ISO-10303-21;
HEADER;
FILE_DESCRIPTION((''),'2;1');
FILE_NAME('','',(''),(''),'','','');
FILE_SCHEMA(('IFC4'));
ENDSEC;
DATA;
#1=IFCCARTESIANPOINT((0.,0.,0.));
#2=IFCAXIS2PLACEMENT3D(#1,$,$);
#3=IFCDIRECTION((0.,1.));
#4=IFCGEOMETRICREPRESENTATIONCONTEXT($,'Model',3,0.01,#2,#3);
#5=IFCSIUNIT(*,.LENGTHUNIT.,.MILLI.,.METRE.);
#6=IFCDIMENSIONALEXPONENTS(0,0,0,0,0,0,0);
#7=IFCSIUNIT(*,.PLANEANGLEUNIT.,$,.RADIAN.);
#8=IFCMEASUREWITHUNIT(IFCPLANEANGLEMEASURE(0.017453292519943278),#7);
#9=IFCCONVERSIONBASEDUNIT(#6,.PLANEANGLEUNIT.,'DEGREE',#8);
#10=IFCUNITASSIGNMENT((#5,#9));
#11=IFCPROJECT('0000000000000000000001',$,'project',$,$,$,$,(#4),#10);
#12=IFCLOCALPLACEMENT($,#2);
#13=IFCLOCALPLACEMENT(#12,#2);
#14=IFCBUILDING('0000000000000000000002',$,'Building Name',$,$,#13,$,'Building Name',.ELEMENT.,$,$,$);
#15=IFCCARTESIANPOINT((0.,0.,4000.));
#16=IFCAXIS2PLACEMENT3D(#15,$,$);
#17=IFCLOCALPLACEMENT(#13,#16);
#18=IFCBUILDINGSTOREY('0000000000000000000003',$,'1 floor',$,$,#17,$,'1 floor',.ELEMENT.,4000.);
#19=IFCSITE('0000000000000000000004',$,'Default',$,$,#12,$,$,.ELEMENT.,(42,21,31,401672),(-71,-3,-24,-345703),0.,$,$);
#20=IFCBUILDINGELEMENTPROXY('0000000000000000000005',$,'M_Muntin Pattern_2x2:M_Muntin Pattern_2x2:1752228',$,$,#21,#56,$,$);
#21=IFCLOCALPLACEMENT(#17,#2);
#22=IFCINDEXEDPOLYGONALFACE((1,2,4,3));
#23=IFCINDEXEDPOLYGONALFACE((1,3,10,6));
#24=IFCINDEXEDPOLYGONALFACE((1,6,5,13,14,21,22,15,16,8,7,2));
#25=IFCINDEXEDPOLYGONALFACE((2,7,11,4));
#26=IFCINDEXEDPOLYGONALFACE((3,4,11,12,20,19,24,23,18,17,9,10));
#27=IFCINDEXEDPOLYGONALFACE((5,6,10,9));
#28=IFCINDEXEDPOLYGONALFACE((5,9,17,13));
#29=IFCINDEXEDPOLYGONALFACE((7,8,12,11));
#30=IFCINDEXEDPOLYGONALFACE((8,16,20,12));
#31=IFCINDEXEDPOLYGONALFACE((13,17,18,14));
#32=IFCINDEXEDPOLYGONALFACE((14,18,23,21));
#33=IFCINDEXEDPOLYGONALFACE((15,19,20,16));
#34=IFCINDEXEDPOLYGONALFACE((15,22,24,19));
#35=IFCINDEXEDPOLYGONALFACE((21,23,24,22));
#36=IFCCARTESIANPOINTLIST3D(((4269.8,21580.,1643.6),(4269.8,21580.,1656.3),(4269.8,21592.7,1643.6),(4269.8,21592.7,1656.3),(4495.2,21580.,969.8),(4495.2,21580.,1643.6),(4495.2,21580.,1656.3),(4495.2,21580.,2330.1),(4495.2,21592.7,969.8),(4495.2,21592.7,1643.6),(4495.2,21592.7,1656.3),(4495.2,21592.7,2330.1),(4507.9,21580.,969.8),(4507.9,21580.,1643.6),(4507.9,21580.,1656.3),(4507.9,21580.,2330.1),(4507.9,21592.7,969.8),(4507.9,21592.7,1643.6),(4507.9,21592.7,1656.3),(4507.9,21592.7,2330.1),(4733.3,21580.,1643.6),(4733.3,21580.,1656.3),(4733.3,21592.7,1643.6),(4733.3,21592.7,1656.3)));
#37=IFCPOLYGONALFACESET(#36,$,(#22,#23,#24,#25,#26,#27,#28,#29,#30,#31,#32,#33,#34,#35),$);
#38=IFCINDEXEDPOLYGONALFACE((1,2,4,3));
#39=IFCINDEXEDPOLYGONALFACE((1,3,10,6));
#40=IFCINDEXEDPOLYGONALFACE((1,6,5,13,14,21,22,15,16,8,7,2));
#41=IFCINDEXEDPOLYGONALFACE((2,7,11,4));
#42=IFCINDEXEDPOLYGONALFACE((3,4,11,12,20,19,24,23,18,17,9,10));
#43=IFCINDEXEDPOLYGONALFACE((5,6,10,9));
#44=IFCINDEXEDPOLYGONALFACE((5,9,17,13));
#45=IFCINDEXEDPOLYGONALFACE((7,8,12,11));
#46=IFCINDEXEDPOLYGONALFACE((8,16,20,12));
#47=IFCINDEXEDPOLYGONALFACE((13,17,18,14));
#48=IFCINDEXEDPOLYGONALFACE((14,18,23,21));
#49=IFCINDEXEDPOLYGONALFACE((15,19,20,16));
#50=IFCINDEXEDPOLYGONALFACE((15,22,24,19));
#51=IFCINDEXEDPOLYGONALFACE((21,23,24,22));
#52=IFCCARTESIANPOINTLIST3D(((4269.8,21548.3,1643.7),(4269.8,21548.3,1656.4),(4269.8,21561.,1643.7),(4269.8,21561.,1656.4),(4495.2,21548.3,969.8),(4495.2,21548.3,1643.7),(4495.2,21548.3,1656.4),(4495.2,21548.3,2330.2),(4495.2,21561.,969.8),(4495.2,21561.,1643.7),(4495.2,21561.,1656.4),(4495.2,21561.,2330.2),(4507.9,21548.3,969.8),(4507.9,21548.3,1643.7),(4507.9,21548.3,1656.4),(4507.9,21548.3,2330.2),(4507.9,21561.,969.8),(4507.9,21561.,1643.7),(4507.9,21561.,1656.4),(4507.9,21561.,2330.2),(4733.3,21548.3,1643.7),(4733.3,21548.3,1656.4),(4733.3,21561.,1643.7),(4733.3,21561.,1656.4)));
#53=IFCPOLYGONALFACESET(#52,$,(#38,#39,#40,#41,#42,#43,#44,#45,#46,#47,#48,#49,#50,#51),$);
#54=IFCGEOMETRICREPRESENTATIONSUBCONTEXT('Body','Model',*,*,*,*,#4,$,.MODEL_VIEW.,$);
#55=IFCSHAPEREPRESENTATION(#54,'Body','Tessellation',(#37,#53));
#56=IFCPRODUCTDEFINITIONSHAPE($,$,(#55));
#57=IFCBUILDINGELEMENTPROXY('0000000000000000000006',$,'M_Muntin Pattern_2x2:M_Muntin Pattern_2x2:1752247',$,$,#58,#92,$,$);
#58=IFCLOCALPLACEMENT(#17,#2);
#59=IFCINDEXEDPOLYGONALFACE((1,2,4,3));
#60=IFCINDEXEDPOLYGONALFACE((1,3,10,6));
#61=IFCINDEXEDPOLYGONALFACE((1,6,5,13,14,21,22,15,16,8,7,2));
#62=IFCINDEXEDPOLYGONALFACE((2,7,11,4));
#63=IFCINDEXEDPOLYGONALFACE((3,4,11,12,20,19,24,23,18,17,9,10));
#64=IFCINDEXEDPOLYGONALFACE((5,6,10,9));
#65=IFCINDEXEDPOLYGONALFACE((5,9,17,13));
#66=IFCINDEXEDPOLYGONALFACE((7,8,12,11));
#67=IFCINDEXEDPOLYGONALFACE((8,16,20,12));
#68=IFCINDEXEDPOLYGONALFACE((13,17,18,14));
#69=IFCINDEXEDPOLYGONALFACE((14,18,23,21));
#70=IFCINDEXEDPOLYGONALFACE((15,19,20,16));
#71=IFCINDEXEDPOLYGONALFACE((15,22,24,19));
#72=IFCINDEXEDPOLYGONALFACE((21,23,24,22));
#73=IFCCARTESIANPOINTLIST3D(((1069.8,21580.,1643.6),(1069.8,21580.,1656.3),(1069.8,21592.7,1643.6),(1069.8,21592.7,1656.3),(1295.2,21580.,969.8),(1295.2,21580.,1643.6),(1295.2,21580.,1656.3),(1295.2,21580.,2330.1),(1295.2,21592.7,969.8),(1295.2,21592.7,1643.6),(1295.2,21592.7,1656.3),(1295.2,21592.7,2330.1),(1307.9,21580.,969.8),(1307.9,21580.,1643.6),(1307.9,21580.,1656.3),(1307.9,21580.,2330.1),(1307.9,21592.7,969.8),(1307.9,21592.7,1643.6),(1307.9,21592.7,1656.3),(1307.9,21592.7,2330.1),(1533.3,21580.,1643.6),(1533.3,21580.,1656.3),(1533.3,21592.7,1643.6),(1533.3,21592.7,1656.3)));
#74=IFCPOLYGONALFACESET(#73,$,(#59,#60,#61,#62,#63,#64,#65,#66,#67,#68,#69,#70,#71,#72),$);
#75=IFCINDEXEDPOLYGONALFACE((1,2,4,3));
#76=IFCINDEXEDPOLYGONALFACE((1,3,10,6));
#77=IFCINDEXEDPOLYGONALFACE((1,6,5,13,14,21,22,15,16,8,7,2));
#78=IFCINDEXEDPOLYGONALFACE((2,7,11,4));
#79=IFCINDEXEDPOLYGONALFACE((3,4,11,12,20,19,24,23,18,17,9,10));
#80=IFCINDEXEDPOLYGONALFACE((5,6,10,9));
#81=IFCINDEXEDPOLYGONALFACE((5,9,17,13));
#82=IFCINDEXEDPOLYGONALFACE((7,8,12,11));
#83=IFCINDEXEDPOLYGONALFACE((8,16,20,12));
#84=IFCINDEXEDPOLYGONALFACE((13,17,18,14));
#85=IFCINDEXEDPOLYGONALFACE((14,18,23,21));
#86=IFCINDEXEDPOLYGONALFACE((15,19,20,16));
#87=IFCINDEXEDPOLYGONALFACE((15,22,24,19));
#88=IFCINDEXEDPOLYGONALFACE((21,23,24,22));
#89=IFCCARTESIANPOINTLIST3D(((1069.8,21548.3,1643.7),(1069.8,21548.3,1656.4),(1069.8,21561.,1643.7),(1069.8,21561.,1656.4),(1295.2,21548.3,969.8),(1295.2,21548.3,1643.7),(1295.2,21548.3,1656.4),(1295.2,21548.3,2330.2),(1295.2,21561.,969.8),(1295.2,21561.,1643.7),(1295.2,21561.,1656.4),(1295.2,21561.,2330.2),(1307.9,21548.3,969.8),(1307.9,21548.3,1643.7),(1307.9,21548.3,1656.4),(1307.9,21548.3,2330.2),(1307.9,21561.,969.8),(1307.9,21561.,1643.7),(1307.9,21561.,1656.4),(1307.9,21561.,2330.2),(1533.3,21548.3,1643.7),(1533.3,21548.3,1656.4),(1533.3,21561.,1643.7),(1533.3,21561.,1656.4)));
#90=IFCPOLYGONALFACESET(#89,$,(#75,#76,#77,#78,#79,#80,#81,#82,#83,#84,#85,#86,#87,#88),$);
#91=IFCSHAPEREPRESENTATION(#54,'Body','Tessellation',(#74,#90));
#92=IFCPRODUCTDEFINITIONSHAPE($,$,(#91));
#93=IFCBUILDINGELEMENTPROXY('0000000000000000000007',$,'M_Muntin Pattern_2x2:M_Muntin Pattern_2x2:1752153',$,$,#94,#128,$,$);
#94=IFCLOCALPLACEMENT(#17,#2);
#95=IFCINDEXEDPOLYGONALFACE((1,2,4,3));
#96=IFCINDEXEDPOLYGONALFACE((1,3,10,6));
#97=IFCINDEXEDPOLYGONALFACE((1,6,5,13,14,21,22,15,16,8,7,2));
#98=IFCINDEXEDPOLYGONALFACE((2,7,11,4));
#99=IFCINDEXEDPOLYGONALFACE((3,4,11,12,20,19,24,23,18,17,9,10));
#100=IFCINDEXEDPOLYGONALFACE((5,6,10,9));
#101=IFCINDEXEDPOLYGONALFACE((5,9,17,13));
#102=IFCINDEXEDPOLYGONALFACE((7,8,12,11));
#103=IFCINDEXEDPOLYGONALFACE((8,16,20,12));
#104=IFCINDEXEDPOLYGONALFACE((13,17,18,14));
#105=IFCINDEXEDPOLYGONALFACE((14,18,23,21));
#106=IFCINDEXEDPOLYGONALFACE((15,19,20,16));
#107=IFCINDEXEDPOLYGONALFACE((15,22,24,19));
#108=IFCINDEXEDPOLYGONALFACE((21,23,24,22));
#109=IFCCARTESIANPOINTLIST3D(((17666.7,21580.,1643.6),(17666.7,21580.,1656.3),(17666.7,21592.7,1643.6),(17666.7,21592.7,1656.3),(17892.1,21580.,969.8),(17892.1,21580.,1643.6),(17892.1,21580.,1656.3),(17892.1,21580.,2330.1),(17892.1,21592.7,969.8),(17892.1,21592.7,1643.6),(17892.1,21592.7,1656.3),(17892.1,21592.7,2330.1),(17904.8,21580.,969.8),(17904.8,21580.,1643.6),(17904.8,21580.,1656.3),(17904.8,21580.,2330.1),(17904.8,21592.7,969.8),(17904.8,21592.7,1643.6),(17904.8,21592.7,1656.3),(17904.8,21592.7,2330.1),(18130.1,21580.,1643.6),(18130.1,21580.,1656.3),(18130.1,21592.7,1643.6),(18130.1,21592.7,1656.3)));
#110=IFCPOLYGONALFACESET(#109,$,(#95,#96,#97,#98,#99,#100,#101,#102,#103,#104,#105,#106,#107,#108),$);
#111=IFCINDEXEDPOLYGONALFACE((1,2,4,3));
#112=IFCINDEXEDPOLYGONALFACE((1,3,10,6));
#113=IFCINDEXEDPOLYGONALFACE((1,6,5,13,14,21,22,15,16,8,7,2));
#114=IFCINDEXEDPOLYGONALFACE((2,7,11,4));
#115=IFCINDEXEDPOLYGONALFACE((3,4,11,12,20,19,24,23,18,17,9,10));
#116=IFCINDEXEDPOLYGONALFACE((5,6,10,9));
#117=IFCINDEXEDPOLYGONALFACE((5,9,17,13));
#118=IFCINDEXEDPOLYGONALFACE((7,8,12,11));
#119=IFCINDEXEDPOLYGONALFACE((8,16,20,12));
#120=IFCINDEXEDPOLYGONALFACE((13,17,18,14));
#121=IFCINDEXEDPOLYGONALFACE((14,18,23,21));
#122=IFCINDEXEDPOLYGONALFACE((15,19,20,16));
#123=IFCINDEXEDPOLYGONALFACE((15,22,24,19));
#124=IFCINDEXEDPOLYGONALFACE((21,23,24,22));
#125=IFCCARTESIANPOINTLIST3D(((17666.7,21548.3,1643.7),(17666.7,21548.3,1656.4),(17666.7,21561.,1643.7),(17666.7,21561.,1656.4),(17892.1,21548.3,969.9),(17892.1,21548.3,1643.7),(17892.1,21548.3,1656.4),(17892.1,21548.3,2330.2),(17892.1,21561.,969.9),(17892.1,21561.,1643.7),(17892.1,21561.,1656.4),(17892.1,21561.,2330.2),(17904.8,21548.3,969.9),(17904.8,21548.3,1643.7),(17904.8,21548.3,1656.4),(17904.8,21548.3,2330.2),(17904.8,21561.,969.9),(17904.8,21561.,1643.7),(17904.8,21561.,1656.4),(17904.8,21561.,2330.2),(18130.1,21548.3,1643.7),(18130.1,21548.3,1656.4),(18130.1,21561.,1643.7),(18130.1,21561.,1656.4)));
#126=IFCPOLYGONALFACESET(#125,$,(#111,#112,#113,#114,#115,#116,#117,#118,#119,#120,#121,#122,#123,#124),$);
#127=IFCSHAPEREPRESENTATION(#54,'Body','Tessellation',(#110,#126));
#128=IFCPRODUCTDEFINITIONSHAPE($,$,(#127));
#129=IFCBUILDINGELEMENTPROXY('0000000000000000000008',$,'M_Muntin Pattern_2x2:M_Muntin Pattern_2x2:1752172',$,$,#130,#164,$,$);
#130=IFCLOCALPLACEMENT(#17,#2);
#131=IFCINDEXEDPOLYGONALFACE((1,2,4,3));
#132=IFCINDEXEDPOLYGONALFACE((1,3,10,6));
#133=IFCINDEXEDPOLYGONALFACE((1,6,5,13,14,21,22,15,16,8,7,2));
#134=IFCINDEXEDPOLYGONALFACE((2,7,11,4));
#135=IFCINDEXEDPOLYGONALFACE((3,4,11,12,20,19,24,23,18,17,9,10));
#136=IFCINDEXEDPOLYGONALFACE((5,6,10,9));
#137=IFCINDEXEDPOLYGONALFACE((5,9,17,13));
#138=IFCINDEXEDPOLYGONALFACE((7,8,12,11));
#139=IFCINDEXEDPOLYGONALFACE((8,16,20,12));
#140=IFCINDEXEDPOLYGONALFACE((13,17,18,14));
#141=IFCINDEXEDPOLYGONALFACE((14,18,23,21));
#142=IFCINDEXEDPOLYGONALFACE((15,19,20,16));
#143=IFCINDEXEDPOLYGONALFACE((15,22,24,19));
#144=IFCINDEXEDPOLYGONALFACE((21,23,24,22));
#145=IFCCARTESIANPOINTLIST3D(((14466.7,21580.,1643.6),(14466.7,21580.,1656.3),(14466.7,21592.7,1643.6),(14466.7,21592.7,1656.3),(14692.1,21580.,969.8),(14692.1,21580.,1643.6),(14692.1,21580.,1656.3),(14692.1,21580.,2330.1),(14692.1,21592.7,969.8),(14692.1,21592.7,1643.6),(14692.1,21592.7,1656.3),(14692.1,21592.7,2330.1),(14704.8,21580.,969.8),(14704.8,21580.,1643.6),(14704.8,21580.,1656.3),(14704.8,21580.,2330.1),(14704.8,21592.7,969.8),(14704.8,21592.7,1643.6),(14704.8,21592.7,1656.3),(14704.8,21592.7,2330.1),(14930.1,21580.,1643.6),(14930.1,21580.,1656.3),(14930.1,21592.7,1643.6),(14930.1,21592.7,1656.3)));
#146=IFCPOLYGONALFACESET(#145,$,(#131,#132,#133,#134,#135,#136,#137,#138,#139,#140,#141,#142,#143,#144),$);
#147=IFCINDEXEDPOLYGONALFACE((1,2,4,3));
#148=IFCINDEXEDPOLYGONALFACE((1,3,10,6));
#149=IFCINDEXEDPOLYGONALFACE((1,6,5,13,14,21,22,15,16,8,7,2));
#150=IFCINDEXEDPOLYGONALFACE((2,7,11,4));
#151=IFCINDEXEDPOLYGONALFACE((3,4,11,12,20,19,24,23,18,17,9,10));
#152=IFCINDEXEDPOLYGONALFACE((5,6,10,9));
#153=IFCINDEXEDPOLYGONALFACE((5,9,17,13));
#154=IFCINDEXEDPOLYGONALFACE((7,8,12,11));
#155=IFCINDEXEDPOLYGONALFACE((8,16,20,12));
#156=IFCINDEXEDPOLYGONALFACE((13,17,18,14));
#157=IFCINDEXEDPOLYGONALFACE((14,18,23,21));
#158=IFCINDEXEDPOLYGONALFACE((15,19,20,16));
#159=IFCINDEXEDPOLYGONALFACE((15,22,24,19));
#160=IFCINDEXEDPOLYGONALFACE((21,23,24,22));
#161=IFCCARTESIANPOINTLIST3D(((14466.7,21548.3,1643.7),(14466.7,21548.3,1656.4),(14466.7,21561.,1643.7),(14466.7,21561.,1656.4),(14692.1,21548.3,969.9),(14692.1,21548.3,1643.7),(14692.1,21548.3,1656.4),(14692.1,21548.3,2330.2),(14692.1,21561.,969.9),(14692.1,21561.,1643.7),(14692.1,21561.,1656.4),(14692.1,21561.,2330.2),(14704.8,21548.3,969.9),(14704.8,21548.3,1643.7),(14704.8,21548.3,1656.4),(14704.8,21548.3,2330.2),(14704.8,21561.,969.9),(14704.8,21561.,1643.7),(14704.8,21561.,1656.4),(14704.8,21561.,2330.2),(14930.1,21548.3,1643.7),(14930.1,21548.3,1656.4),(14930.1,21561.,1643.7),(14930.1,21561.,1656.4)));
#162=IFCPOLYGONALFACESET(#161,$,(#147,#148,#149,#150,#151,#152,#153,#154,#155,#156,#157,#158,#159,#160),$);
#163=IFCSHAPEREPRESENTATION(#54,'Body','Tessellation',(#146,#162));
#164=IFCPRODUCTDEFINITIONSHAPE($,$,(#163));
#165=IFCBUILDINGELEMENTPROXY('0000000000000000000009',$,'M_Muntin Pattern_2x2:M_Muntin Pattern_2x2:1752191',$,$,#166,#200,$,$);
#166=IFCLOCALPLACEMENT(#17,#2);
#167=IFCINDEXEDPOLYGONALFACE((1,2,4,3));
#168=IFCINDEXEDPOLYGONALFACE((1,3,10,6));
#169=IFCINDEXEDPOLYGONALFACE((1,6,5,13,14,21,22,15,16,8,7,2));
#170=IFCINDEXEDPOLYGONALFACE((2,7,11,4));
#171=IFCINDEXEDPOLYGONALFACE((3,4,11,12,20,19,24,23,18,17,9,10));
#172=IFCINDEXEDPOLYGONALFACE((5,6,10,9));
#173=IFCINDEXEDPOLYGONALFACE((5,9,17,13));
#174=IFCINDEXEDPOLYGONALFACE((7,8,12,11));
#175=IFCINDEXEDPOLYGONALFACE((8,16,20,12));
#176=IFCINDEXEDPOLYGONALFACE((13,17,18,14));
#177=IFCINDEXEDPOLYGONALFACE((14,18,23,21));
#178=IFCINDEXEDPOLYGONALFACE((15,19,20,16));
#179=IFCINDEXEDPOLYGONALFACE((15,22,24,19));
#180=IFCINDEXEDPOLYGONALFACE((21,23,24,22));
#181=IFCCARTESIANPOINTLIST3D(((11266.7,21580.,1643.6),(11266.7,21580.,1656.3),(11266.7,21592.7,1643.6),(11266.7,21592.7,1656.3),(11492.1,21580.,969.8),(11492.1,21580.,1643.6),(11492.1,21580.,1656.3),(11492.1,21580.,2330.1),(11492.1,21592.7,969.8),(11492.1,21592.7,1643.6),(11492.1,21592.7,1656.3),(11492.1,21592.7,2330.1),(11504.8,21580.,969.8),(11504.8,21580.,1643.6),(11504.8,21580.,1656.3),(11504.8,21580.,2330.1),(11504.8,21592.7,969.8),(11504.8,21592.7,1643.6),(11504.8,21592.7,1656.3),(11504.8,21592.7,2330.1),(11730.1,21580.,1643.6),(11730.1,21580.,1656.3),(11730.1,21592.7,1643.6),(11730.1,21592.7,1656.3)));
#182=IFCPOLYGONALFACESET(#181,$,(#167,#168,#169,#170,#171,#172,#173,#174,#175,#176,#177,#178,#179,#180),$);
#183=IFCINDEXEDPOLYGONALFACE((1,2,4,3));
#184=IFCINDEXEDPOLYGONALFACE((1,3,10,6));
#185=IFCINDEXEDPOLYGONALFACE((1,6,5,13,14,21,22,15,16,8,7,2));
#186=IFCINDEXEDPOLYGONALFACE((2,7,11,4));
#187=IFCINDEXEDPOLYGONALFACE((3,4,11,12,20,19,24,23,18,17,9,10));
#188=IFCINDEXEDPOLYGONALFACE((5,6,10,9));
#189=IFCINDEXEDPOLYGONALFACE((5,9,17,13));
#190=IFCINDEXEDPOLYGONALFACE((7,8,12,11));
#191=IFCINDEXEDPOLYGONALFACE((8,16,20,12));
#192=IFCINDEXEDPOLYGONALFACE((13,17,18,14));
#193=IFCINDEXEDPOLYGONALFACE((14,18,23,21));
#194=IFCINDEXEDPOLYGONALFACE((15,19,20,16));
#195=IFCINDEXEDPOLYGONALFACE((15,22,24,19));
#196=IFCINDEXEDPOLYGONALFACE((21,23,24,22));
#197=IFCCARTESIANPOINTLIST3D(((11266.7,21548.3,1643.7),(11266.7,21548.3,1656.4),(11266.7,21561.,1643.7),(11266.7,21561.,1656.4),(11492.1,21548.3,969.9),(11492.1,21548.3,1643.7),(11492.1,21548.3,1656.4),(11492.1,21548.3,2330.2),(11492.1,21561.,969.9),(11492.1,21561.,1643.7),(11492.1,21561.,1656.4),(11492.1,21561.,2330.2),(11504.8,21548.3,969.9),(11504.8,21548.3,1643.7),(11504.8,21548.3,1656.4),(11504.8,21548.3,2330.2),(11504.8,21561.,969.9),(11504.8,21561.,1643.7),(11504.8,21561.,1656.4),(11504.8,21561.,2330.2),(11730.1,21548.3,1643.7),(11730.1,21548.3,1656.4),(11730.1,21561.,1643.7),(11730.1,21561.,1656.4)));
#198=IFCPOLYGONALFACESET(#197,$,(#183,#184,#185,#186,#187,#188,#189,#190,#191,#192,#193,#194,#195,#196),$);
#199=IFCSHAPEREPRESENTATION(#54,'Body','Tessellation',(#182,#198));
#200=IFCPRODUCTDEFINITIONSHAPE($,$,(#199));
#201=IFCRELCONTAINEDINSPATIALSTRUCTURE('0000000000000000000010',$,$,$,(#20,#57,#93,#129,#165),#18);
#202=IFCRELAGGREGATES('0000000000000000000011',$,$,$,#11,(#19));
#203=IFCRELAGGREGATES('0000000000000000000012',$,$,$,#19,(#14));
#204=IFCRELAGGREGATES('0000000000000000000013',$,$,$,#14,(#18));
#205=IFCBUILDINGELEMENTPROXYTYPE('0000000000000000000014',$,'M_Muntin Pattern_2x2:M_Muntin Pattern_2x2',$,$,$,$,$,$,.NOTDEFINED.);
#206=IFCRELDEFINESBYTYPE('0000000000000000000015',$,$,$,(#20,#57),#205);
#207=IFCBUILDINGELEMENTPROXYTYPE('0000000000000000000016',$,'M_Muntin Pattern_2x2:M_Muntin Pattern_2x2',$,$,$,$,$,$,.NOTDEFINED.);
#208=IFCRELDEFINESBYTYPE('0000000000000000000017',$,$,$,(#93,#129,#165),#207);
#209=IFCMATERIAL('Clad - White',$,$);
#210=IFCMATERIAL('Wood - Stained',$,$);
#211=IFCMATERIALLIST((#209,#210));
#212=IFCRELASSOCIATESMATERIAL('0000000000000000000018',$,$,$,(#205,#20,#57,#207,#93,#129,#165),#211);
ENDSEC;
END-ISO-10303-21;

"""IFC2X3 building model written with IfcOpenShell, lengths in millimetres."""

from ifc_helpers import new_model, entity, si_unit, converted_unit, direction, frame, origin, place, context, subcontext, project, spatial, polyline, outline, extrude, source, transform, mapped, material, material_list, type_object, type_shapes, element, save


model = new_model("IFC2X3")

# Units and contexts
model_context = context("Model", 3, precision=0.01, world=origin(), true_north=direction((0.0, 1.0)))
body_context = subcontext(model_context, "Body", "Model", "MODEL_VIEW")
ifc_project = project(units=[si_unit("LENGTHUNIT", "METRE", prefix="MILLI"), converted_unit("PLANEANGLEUNIT", "DEGREE", entity("IfcPlaneAngleMeasure", 0.017453292519943278), si_unit("PLANEANGLEUNIT", "RADIAN"), dimensions=[0, 0, 0, 0, 0, 0, 0])], contexts=[model_context])

# Site, building, storey
site_placement = place(None, origin())
site = spatial("IfcSite", under=ifc_project, at=site_placement, Name="Default", CompositionType="ELEMENT", RefLatitude=(42, 21, 31, 401672), RefLongitude=(-71, -3, -24, -345703), RefElevation=0.0)
building_placement = place(site_placement, origin())
building = spatial("IfcBuilding", under=site, at=building_placement, Name="Building Name", LongName="Building Name", CompositionType="ELEMENT")
storey_placement = place(building_placement, frame((0.0, 0.0, 4000.0)))
storey = spatial("IfcBuildingStorey", under=building, at=storey_placement, Name="1 floor", LongName="1 floor", CompositionType="ELEMENT", Elevation=4000.0)

# Building element proxies
ifc_material_1 = material(Name="Clad - White")
ifc_material_2 = material(Name="Wood - Stained")
ifc_material_list = material_list([ifc_material_1, ifc_material_2])
building_element_proxy_type_1 = type_object("IfcBuildingElementProxyType", Name="M_Muntin Pattern_2x2:M_Muntin Pattern_2x2", PredefinedType="NOTDEFINED", material=ifc_material_list)
shared_shape_1 = source(origin(), body_context, "Body", "SweptSolid", [
    extrude(outline(polyline([(6.4, -6.4), (680.1, -6.4), (680.1, 6.3), (6.4, 6.3), (6.4, 231.7), (-6.3, 231.7), (-6.3, 6.3), (-680.2, 6.3), (-680.2, -6.4), (-6.3, -6.4), (-6.3, -231.7), (6.4, -231.7), (6.4, -6.4)])), frame((0.0, 9.5, 680.1), z_axis=(0.0, 1.0, 0.0), x_axis=(0.0, 0.0, 1.0)), (0.0, 0.0, 1.0), 12.7),
    extrude(outline(polyline([(6.4, -6.4), (680.2, -6.4), (680.2, 6.3), (6.4, 6.3), (6.4, 231.7), (-6.3, 231.7), (-6.3, 6.3), (-680.2, 6.3), (-680.2, -6.4), (-6.3, -6.4), (-6.3, -231.7), (6.4, -231.7), (6.4, -6.4)])), frame((0.0, -22.2, 680.2), z_axis=(0.0, 1.0, 0.0), x_axis=(0.0, 0.0, 1.0)), (0.0, 0.0, 1.0), 12.7),
])
type_shapes(building_element_proxy_type_1, [shared_shape_1])
for number, where, name in (
    (1, (4501.6, 21570.5, 969.8), "M_Muntin Pattern_2x2:M_Muntin Pattern_2x2:1752228"),
    (2, (1301.6, 21570.5, 969.8), "M_Muntin Pattern_2x2:M_Muntin Pattern_2x2:1752247"),
):
    element("IfcBuildingElementProxy", number, at=place(storey_placement, frame(where)), inside=storey, type_object=building_element_proxy_type_1, material=ifc_material_list, Name=name, context=body_context, shape_type="MappedRepresentation", body=[
        mapped(shared_shape_1, transform((0.0, 0.0, 0.0), scale=1.0)),
    ])
building_element_proxy_type_2 = type_object("IfcBuildingElementProxyType", Name="M_Muntin Pattern_2x2:M_Muntin Pattern_2x2", PredefinedType="NOTDEFINED", material=ifc_material_list)
shared_shape_2 = source(origin(), body_context, "Body", "SweptSolid", [
    extrude(outline(polyline([(6.4, -6.4), (680.1, -6.4), (680.1, 6.3), (6.4, 6.3), (6.4, 231.7), (-6.3, 231.7), (-6.3, 6.3), (-680.2, 6.3), (-680.2, -6.4), (-6.3, -6.4), (-6.3, -231.7), (6.4, -231.7), (6.4, -6.4)])), frame((0.0, -22.2, 680.1), z_axis=(0.0, 1.0, 0.0), x_axis=(0.0, 0.0, 1.0)), (0.0, 0.0, 1.0), 12.7),
    extrude(outline(polyline([(6.4, -6.4), (680.2, -6.4), (680.2, 6.3), (6.4, 6.3), (6.4, 231.7), (-6.3, 231.7), (-6.3, 6.3), (-680.2, 6.3), (-680.2, -6.4), (-6.3, -6.4), (-6.3, -231.7), (6.4, -231.7), (6.4, -6.4)])), frame((0.0, 9.5, 680.2), z_axis=(0.0, 1.0, 0.0), x_axis=(0.0, 0.0, 1.0)), (0.0, 0.0, 1.0), 12.7),
])
type_shapes(building_element_proxy_type_2, [shared_shape_2])
for number, where, z_axis, x_axis, name in (
    (3, (17898.4, 21570.5, 969.9), (0.0, 0.0, 1.0), (-1.0, 0.0, 0.0), "M_Muntin Pattern_2x2:M_Muntin Pattern_2x2:1752153"),
    (4, (14698.4, 21570.5, 969.9), (0.0, 0.0, 1.0), (-1.0, 0.0, 0.0), "M_Muntin Pattern_2x2:M_Muntin Pattern_2x2:1752172"),
    (5, (11498.4, 21570.5, 969.9), (0.0, 0.0, 1.0), (-1.0, 0.0, 0.0), "M_Muntin Pattern_2x2:M_Muntin Pattern_2x2:1752191"),
):
    element("IfcBuildingElementProxy", number, at=place(storey_placement, frame(where, z_axis=z_axis, x_axis=x_axis)), inside=storey, type_object=building_element_proxy_type_2, material=ifc_material_list, Name=name, context=body_context, shape_type="MappedRepresentation", body=[
        mapped(shared_shape_2, transform((0.0, 0.0, 0.0), scale=1.0)),
    ])

save(model, "model.ifc")
